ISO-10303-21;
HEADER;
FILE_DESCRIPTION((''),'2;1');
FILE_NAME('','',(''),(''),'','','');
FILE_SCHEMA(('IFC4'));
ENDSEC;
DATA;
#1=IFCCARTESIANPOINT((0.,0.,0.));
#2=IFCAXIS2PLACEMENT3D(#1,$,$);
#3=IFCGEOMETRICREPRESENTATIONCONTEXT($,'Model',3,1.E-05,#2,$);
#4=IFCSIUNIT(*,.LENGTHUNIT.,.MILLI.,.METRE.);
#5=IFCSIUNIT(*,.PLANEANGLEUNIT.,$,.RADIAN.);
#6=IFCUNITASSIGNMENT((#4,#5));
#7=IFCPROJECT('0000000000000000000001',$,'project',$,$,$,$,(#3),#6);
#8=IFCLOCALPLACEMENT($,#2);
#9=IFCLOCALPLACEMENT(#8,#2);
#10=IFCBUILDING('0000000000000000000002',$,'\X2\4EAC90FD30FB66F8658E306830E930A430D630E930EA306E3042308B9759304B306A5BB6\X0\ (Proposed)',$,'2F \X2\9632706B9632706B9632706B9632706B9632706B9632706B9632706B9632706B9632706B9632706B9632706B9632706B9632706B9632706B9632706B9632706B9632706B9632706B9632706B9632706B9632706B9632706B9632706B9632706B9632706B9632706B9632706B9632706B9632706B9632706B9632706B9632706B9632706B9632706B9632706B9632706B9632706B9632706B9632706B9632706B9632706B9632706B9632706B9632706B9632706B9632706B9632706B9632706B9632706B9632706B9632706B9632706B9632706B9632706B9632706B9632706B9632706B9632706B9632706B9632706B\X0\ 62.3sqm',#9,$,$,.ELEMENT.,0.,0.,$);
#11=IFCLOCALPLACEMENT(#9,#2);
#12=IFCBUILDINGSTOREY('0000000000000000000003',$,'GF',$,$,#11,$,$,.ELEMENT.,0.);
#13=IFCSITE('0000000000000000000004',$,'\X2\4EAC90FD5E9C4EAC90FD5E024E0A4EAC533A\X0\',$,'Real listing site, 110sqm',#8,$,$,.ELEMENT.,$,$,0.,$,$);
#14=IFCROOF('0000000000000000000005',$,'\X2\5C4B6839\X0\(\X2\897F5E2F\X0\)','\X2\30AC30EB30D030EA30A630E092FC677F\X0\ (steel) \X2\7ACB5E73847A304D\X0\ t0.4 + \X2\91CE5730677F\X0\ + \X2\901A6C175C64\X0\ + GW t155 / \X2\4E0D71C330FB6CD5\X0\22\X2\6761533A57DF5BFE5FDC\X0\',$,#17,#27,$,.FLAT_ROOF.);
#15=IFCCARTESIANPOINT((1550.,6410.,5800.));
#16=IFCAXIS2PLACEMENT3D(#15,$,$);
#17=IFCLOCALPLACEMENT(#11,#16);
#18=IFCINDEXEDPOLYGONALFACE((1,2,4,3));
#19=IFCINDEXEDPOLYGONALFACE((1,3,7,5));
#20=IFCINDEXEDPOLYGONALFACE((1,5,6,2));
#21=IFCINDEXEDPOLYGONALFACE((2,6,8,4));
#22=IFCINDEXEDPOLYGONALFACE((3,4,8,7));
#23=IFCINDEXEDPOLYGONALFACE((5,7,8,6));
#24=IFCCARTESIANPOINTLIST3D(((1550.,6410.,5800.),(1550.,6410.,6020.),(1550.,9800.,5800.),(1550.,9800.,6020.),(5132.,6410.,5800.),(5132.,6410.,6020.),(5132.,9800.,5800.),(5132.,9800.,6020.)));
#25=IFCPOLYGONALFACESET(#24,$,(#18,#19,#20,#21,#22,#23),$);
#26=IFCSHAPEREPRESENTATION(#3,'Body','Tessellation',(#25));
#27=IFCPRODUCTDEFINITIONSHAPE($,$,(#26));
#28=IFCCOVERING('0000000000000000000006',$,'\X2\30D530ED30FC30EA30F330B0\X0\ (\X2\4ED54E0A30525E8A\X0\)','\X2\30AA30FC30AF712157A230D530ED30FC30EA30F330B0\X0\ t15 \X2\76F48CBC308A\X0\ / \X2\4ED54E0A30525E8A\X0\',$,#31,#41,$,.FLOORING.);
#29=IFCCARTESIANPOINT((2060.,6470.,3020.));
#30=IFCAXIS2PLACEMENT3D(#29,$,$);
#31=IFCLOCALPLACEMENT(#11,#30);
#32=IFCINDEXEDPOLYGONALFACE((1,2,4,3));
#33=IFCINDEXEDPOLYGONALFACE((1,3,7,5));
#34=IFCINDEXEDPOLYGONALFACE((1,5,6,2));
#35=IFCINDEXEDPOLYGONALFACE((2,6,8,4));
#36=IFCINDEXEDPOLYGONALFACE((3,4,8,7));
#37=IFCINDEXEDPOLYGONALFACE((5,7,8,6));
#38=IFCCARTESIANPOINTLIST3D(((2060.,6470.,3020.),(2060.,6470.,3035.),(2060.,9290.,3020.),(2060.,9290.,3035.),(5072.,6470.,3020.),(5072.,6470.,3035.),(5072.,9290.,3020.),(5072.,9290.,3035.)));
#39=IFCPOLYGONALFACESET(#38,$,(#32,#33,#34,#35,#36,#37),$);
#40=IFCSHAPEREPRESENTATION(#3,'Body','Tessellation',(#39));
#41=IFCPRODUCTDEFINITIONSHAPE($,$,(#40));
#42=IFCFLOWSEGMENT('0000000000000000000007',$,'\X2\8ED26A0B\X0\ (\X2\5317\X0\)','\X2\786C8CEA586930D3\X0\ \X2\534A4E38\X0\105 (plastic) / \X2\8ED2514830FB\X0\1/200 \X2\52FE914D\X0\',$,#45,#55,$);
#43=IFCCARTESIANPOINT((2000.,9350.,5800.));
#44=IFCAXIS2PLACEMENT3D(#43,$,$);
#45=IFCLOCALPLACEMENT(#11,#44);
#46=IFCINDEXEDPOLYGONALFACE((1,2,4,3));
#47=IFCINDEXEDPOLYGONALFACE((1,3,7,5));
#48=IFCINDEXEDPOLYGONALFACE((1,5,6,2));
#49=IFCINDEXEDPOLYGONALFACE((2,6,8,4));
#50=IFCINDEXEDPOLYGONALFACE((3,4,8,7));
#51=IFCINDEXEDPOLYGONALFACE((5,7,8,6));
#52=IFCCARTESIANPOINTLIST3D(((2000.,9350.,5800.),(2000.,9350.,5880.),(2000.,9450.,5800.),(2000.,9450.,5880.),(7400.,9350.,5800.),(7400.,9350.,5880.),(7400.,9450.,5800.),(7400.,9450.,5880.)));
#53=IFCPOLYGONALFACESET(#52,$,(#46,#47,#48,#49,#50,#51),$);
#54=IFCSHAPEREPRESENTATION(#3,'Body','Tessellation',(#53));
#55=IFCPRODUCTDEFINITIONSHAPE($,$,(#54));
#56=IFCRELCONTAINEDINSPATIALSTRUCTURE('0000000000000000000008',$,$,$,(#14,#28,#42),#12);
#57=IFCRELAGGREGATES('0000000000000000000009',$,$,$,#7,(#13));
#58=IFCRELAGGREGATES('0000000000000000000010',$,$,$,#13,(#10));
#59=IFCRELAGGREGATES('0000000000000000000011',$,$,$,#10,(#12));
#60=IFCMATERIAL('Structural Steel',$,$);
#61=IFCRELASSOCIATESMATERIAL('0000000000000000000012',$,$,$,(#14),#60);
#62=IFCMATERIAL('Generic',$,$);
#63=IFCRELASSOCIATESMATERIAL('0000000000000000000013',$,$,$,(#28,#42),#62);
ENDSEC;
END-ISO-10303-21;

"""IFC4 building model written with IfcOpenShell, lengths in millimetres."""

from ifc_helpers import new_model, si_unit, frame, frame_2d, origin, place, context, project, spatial, rectangle, extrude, material, element, save


model = new_model("IFC4")

# Units and contexts
model_context = context("Model", 3, precision=1e-05, world=origin())
ifc_project = project(units=[si_unit("LENGTHUNIT", "METRE", prefix="MILLI"), si_unit("PLANEANGLEUNIT", "RADIAN")], contexts=[model_context])

# Site, building, storey
site_placement = place(None, origin())
site = spatial("IfcSite", under=ifc_project, at=site_placement, Name="京都府京都市上京区", ObjectType="Real listing site, 110sqm", CompositionType="ELEMENT", RefElevation=0.0)
building_placement = place(site_placement, origin())
building = spatial("IfcBuilding", under=site, at=building_placement, Name="京都・書斎とライブラリのある静かな家 (Proposed)", ObjectType="2F 防火防火防火防火防火防火防火防火防火防火防火防火防火防火防火防火防火防火防火防火防火防火防火防火防火防火防火防火防火防火防火防火防火防火防火防火防火防火防火防火防火防火防火防火防火防火防火防火防火防火防火防火防火防火防火防火防火防火防火防火 62.3sqm", CompositionType="ELEMENT", ElevationOfRefHeight=0.0, ElevationOfTerrain=0.0)
storey_placement = place(building_placement, origin())
storey = spatial("IfcBuildingStorey", under=building, at=storey_placement, Name="GF", CompositionType="ELEMENT", Elevation=0.0)

# Roof
ifc_material_1 = material(Name="Structural Steel")
for number, where, name in (
    (1, (1550.0, 6410.0, 5800.0), "屋根(西帯)"),
):
    element("IfcRoof", number, at=place(storey_placement, frame(where)), inside=storey, material=ifc_material_1, Name=name, Description="ガルバリウム鋼板 (steel) 立平葺き t0.4 + 野地板 + 通気層 + GW t155 / 不燃・法22条区域対応", PredefinedType="FLAT_ROOF", context=model_context, shape_type="SweptSolid", body=[
        extrude(rectangle(XDim=3582.0, YDim=3390.0, at=frame_2d((1791.0, 1695.0))), frame((1550.0, 6410.0, 5800.0)), (0.0, 0.0, 1.0), 220.0),
    ])

# Covering
ifc_material_2 = material(Name="Generic")
covering_placement = place(storey_placement, frame((2060.0, 6470.0, 3020.0)))
element("IfcCovering", 2, at=covering_placement, inside=storey, material=ifc_material_2, Name="フローリング (仕上げ床)", Description="オーク無垢フローリング t15 直貼り / 仕上げ床", PredefinedType="FLOORING", context=model_context, shape_type="SweptSolid", body=[
    extrude(rectangle(XDim=3012.0, YDim=2820.0, at=frame_2d((1506.0, 1410.0))), frame((2060.0, 6470.0, 3020.0)), (0.0, 0.0, 1.0), 15.0),
])

# Flow segment
flow_segment_placement = place(storey_placement, frame((2000.0, 9350.0, 5800.0)))
element("IfcFlowSegment", 3, at=flow_segment_placement, inside=storey, material=ifc_material_2, Name="軒樋 (北)", Description="硬質塩ビ 半丸105 (plastic) / 軒先・1/200 勾配", context=model_context, shape_type="SweptSolid", body=[
    extrude(rectangle(XDim=5400.0, YDim=100.0, at=frame_2d((2700.0, 50.0))), frame((2000.0, 9350.0, 5800.0)), (0.0, 0.0, 1.0), 80.0),
])

save(model, "model.ifc")
